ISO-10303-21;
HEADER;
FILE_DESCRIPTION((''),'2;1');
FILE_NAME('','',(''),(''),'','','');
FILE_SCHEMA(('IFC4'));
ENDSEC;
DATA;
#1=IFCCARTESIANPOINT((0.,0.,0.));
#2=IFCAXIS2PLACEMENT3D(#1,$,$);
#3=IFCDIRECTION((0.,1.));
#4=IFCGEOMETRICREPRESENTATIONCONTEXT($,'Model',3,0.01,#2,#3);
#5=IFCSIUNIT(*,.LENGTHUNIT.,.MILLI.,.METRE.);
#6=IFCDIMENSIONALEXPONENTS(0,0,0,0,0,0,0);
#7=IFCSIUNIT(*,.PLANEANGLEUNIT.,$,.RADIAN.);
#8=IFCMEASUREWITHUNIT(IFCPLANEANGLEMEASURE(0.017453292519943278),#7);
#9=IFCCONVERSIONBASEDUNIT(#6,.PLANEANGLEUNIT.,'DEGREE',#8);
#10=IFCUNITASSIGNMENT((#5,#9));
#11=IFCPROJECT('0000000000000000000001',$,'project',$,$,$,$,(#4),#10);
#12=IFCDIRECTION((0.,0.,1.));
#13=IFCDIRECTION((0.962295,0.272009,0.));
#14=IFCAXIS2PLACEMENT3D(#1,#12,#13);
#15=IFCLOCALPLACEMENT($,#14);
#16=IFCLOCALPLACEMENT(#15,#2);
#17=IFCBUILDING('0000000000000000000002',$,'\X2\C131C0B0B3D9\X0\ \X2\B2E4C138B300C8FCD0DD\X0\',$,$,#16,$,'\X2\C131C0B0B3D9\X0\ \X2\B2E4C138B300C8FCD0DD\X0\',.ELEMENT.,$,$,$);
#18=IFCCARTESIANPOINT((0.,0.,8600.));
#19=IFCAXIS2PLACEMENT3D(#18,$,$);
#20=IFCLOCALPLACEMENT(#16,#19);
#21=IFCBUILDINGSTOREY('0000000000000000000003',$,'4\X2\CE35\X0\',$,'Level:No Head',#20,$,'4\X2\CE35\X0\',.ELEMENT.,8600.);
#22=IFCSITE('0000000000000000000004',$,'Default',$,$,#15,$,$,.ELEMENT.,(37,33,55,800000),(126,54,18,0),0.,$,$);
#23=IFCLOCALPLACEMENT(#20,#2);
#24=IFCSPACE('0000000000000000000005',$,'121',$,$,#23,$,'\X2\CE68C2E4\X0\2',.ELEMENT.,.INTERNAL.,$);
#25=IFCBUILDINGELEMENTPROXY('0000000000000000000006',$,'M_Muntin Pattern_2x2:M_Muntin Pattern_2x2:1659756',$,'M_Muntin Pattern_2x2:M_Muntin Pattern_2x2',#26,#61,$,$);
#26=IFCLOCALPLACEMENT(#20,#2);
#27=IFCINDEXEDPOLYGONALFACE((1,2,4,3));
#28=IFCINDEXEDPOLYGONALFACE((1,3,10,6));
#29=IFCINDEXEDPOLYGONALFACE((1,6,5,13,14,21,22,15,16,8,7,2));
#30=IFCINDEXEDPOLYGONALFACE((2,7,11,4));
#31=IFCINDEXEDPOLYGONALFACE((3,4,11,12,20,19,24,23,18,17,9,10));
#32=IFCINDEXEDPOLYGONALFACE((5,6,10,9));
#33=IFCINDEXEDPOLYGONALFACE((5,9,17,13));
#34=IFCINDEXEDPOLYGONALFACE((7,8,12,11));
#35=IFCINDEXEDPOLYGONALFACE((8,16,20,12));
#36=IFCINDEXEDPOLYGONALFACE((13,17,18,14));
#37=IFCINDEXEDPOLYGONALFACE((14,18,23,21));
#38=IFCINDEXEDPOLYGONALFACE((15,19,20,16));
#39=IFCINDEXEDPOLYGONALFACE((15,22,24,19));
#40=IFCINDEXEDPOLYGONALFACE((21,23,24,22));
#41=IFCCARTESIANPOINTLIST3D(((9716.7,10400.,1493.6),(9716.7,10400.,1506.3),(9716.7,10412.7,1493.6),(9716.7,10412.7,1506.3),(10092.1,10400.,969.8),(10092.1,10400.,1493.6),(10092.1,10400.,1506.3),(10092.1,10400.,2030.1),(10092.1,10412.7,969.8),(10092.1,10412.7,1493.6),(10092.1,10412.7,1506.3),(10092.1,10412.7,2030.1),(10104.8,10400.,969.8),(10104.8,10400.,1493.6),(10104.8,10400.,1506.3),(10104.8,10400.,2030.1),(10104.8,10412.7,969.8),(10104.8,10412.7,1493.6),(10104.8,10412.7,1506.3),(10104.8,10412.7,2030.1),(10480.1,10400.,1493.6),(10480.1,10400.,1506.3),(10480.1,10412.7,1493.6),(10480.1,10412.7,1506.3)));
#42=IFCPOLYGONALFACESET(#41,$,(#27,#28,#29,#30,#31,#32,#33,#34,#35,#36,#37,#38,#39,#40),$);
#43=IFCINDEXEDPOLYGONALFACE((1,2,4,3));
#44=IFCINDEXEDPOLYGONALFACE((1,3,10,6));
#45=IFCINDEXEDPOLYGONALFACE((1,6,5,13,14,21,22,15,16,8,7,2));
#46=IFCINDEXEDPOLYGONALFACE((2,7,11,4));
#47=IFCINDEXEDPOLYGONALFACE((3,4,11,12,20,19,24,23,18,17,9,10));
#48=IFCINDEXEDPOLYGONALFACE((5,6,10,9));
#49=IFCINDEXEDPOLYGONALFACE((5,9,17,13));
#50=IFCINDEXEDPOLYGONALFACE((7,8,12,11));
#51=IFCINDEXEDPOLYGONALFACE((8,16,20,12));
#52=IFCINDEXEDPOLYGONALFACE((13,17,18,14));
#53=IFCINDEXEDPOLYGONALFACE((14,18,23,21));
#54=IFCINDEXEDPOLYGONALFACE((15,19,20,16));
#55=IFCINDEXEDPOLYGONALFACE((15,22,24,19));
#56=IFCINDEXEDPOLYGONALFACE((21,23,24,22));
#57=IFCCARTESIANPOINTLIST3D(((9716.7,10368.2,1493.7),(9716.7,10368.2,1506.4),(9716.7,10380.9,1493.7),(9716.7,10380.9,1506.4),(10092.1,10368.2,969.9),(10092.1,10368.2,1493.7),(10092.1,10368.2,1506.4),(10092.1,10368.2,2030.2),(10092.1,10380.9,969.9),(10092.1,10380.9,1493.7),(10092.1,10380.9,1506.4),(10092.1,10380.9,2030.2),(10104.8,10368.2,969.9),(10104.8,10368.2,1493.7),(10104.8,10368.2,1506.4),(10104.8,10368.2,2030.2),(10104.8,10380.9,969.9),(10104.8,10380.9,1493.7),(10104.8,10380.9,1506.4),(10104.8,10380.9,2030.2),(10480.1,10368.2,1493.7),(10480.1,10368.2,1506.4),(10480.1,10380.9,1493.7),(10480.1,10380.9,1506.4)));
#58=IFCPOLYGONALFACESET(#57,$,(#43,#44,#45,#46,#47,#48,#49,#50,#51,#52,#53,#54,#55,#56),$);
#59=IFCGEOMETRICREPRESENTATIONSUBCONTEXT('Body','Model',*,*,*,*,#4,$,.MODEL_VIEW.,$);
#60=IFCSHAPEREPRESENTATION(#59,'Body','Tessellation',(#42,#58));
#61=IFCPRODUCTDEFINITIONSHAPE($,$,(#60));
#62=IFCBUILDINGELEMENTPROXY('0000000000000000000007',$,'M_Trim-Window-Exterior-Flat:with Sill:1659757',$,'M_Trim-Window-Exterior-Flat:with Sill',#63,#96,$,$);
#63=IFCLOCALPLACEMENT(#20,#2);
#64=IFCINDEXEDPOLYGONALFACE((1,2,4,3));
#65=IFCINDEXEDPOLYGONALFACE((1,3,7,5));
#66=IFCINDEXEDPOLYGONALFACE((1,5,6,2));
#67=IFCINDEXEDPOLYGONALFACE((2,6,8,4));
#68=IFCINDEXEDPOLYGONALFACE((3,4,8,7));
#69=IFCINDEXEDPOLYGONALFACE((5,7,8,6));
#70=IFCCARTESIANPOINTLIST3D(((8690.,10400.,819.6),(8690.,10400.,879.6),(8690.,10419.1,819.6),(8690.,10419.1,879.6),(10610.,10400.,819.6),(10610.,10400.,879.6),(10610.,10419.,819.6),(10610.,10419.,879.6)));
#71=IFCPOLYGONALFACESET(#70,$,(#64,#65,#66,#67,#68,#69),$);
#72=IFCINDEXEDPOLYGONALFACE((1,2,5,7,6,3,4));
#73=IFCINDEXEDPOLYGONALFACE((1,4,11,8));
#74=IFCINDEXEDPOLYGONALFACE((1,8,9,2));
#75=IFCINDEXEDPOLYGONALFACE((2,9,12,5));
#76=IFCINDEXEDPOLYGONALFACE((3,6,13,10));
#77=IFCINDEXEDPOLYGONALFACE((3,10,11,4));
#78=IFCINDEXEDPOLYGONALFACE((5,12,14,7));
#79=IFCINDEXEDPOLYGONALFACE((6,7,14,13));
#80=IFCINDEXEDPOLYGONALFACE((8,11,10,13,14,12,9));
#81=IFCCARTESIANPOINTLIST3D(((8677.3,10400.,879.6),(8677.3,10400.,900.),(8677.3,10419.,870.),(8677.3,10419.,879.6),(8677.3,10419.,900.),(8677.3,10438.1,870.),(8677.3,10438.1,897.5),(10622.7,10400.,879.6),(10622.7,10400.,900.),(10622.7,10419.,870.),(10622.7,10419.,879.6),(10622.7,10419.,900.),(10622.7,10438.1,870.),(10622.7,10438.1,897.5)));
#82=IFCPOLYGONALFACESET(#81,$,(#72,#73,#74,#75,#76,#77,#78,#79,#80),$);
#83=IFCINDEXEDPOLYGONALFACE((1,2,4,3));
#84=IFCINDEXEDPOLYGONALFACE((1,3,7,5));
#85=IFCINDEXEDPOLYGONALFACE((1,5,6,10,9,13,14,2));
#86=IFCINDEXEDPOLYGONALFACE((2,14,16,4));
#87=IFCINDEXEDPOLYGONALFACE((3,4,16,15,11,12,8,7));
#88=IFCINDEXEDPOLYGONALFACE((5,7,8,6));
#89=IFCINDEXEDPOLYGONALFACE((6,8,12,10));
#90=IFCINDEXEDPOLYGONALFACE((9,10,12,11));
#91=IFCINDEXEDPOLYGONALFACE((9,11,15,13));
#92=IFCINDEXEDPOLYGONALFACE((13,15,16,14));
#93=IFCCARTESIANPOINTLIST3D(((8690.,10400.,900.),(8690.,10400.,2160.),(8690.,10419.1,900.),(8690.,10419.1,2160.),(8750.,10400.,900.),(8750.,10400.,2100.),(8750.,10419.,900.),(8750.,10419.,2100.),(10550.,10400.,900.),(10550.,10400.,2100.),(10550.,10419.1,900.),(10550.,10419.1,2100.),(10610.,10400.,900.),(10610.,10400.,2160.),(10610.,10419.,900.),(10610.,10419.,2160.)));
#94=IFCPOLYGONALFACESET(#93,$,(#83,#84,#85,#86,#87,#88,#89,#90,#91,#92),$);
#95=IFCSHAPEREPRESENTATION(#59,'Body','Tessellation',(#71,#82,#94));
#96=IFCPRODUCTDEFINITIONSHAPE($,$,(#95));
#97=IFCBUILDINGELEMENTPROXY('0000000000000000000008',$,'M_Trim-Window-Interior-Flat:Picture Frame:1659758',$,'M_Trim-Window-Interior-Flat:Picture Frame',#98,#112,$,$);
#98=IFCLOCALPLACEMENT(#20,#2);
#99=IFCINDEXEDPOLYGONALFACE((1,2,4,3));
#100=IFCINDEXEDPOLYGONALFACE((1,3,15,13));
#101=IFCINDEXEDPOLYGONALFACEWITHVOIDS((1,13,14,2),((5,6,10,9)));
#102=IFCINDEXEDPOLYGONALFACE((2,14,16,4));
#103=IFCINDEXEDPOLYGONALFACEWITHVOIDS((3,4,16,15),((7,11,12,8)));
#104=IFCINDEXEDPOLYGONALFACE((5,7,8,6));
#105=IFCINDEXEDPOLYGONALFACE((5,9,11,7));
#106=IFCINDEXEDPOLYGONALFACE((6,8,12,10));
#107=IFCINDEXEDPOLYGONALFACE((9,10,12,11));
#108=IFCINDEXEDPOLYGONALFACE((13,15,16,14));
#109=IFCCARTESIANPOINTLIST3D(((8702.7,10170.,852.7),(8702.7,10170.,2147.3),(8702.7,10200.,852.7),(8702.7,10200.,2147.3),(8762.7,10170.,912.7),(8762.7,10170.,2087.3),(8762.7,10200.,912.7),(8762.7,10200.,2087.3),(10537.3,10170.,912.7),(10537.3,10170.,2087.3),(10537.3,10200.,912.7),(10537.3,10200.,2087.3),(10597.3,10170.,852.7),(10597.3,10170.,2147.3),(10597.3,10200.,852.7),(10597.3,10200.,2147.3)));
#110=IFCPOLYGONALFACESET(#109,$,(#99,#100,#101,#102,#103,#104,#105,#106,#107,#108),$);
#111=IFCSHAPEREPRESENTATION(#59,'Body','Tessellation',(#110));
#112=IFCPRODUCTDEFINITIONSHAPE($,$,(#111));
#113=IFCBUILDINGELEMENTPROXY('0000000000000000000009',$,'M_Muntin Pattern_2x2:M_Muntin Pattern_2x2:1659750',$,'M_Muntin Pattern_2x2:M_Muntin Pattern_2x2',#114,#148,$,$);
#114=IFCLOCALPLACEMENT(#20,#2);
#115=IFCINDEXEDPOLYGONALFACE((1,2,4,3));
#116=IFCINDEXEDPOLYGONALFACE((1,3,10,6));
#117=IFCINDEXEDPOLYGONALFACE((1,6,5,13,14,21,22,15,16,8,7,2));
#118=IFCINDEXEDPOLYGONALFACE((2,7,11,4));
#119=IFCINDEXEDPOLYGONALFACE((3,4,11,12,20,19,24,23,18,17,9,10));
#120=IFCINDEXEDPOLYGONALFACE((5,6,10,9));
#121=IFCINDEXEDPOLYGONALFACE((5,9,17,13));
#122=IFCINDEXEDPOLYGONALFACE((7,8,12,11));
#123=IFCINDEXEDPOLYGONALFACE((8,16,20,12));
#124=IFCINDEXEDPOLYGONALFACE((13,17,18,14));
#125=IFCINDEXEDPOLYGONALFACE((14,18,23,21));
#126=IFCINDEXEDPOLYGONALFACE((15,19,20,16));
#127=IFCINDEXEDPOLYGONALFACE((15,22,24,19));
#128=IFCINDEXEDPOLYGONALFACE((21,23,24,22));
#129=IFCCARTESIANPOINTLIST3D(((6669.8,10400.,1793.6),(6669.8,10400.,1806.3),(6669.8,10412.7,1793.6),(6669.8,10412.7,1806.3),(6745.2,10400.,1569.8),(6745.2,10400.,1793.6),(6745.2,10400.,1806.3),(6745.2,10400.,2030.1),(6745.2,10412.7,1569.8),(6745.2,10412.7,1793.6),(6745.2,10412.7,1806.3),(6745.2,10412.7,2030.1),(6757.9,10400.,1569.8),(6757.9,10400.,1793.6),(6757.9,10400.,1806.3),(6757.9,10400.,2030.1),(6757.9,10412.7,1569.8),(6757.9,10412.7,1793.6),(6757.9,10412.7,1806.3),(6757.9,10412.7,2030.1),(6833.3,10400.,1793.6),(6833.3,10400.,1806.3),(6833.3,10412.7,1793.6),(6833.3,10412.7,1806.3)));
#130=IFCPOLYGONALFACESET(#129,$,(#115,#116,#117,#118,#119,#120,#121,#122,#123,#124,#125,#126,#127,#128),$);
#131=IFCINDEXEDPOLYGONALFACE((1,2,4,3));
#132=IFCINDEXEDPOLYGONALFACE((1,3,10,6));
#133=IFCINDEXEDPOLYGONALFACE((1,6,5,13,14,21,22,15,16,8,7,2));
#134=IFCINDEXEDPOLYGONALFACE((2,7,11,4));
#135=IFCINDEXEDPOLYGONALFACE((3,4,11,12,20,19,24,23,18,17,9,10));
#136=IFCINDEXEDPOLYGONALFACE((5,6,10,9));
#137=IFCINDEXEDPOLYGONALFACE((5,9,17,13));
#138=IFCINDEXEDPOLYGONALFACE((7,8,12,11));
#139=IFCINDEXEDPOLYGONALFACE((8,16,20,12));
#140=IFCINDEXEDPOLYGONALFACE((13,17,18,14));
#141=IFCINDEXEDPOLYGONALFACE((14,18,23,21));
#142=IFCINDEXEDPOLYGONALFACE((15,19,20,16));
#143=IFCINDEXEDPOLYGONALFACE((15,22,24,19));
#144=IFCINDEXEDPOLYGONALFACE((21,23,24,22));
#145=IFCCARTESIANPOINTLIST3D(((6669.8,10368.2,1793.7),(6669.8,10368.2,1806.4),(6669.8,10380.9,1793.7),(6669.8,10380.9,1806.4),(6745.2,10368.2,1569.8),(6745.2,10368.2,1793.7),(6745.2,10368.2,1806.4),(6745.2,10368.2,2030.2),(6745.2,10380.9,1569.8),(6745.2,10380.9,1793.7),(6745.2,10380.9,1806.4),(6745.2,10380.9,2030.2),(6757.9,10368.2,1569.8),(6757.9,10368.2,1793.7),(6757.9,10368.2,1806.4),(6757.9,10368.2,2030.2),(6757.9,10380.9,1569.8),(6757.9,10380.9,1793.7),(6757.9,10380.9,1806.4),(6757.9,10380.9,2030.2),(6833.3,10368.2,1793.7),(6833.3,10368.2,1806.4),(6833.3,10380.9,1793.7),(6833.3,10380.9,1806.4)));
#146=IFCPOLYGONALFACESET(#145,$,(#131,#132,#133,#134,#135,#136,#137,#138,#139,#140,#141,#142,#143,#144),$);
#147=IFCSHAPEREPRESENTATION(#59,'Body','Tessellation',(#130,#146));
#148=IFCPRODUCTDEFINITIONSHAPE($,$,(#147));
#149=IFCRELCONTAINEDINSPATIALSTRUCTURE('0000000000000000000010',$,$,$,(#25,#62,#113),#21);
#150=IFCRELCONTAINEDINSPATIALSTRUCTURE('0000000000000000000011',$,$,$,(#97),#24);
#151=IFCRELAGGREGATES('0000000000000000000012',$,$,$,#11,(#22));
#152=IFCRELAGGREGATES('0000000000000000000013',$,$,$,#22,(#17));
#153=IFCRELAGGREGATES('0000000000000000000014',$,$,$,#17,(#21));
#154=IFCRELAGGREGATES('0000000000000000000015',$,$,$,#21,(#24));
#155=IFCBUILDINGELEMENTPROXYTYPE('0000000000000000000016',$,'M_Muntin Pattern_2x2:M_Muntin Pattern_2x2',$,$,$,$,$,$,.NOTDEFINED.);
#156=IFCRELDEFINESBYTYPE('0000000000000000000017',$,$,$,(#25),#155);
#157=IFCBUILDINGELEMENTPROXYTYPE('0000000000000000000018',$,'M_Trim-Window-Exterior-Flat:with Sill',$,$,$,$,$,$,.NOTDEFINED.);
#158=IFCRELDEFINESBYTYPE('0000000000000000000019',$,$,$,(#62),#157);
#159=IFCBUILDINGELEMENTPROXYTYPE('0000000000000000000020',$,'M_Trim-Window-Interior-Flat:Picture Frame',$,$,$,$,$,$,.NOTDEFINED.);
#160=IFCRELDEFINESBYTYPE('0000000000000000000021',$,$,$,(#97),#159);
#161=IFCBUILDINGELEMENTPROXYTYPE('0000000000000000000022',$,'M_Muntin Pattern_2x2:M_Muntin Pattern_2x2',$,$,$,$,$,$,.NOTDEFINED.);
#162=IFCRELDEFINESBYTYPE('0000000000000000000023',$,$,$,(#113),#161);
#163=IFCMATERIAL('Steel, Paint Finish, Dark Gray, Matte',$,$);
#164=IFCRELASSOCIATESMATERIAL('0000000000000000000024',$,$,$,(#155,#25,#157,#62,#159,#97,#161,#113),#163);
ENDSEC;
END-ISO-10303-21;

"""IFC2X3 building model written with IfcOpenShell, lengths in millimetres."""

from ifc_helpers import new_model, entity, si_unit, converted_unit, direction, frame, frame_2d, origin, place, context, subcontext, project, spatial, polyline, rectangle, outline, extrude, source, transform, mapped, material, type_object, type_shapes, element, save


model = new_model("IFC2X3")

# Units and contexts
model_context = context("Model", 3, precision=0.01, world=origin(), true_north=direction((0.0, 1.0)))
body_context = subcontext(model_context, "Body", "Model", "MODEL_VIEW")
ifc_project = project(units=[si_unit("LENGTHUNIT", "METRE", prefix="MILLI"), converted_unit("PLANEANGLEUNIT", "DEGREE", entity("IfcPlaneAngleMeasure", 0.017453292519943278), si_unit("PLANEANGLEUNIT", "RADIAN"), dimensions=[0, 0, 0, 0, 0, 0, 0])], contexts=[model_context])

# Site, building, storey
site_placement = place(None, frame((0.0, 0.0, 0.0), z_axis=(0.0, 0.0, 1.0), x_axis=(0.962295, 0.272009, 0.0)))
site = spatial("IfcSite", under=ifc_project, at=site_placement, Name="Default", CompositionType="ELEMENT", RefLatitude=(37, 33, 55, 800000), RefLongitude=(126, 54, 18, 0), RefElevation=0.0)
building_placement = place(site_placement, origin())
building = spatial("IfcBuilding", under=site, at=building_placement, Name="성산동 다세대주택", LongName="성산동 다세대주택", CompositionType="ELEMENT")
storey_placement = place(building_placement, frame((0.0, 0.0, 8600.0)))
storey = spatial("IfcBuildingStorey", under=building, at=storey_placement, Name="4층", ObjectType="Level:No Head", LongName="4층", CompositionType="ELEMENT", Elevation=8600.0)

# Shared definitions
space_1_placement = place(storey_placement, origin())
space_1 = spatial("IfcSpace", under=storey, at=space_1_placement, Name="121", LongName="침실2", CompositionType="ELEMENT", InteriorOrExteriorSpace="INTERNAL")

# Building element proxies
ifc_material_1 = material(Name="Steel, Paint Finish, Dark Gray, Matte")
building_element_proxy_type_1 = type_object("IfcBuildingElementProxyType", Name="M_Muntin Pattern_2x2:M_Muntin Pattern_2x2", PredefinedType="NOTDEFINED", material=ifc_material_1)
shared_shape_1 = source(origin(), body_context, "Body", "SweptSolid", [
    extrude(outline(polyline([(6.4, -6.4), (530.1, -6.4), (530.1, 6.3), (6.4, 6.3), (6.4, 381.7), (-6.3, 381.7), (-6.3, 6.3), (-530.2, 6.3), (-530.2, -6.4), (-6.3, -6.4), (-6.3, -381.7), (6.4, -381.7), (6.4, -6.4)])), frame((0.0, -22.2, 530.1), z_axis=(0.0, 1.0, 0.0), x_axis=(0.0, 0.0, 1.0)), (0.0, 0.0, 1.0), 12.7),
    extrude(outline(polyline([(6.4, -6.4), (530.2, -6.4), (530.2, 6.3), (6.4, 6.3), (6.4, 381.7), (-6.3, 381.7), (-6.3, 6.3), (-530.2, 6.3), (-530.2, -6.4), (-6.3, -6.4), (-6.3, -381.7), (6.4, -381.7), (6.4, -6.4)])), frame((0.0, 9.5, 530.2), z_axis=(0.0, 1.0, 0.0), x_axis=(0.0, 0.0, 1.0)), (0.0, 0.0, 1.0), 12.7),
])
type_shapes(building_element_proxy_type_1, [shared_shape_1])
proxy_1_placement = place(storey_placement, frame((10098.4, 10390.5, 969.9), z_axis=(0.0, 0.0, 1.0), x_axis=(-1.0, 0.0, 0.0)))
element("IfcBuildingElementProxy", 1, at=proxy_1_placement, inside=storey, type_object=building_element_proxy_type_1, material=ifc_material_1, Name="M_Muntin Pattern_2x2:M_Muntin Pattern_2x2:1659756", ObjectType="M_Muntin Pattern_2x2:M_Muntin Pattern_2x2", context=body_context, shape_type="MappedRepresentation", body=[
    mapped(shared_shape_1, transform((0.0, 0.0, 0.0), scale=1.0)),
])
building_element_proxy_type_2 = type_object("IfcBuildingElementProxyType", Name="M_Trim-Window-Exterior-Flat:with Sill", PredefinedType="NOTDEFINED", material=ifc_material_1)
shared_shape_2 = source(origin(), body_context, "Body", "SweptSolid", [
    extrude(rectangle(XDim=1920.0, YDim=60.0, at=frame_2d((0.0, 0.0), x_axis=(1.0, 0.0))), frame((0.0, -1250.4, 0.0), z_axis=(0.0, 0.0, 1.0), x_axis=(-1.0, 0.0, 0.0)), (0.0, 0.0, 1.0), 19.0),
    extrude(outline(polyline([(-19.0, -15.2), (0.0, -15.2), (0.0, -5.7), (19.0, -5.7), (19.0, 14.8), (0.0, 14.8), (-19.0, 12.3), (-19.0, -15.2)])), frame((-972.7, -1214.8, 19.0), z_axis=(1.0, 0.0, 0.0), x_axis=(0.0, 0.0, -1.0)), (0.0, 0.0, 1.0), 1945.4),
    extrude(outline(polyline([(-645.0, -960.0), (615.0, -960.0), (615.0, -900.0), (-585.0, -900.0), (-585.0, 900.0), (615.0, 900.0), (615.0, 960.0), (-645.0, 960.0), (-645.0, -960.0)])), frame((0.0, -585.0, 0.0), z_axis=(0.0, 0.0, 1.0), x_axis=(0.0, -1.0, 0.0)), (0.0, 0.0, 1.0), 19.0),
])
type_shapes(building_element_proxy_type_2, [shared_shape_2])
proxy_2_placement = place(storey_placement, frame((9650.0, 10400.0, 2100.0), z_axis=(0.0, 1.0, 0.0), x_axis=(-1.0, 0.0, 0.0)))
element("IfcBuildingElementProxy", 2, at=proxy_2_placement, inside=storey, type_object=building_element_proxy_type_2, material=ifc_material_1, Name="M_Trim-Window-Exterior-Flat:with Sill:1659757", ObjectType="M_Trim-Window-Exterior-Flat:with Sill", context=body_context, shape_type="MappedRepresentation", body=[
    mapped(shared_shape_2, transform((0.0, 0.0, 0.0), scale=1.0)),
])
building_element_proxy_type_3 = type_object("IfcBuildingElementProxyType", Name="M_Trim-Window-Interior-Flat:Picture Frame", PredefinedType="NOTDEFINED", material=ifc_material_1)
shared_shape_3 = source(origin(), body_context, "Body", "SweptSolid", [
    extrude(outline(polyline([(-947.3, -647.3), (947.3, -647.3), (947.3, 647.3), (-947.3, 647.3), (-947.3, -647.3)]), holes=[polyline([(-887.3, -587.3), (-887.3, 587.3), (887.3, 587.3), (887.3, -587.3), (-887.3, -587.3)])]), frame((0.0, -600.0, 0.0), z_axis=(0.0, 0.0, 1.0), x_axis=(-1.0, 0.0, 0.0)), (0.0, 0.0, 1.0), 30.0),
])
type_shapes(building_element_proxy_type_3, [shared_shape_3])
proxy_3_placement = place(space_1_placement, frame((9650.0, 10200.0, 2100.0), z_axis=(0.0, -1.0, 0.0), x_axis=(1.0, 0.0, 0.0)))
element("IfcBuildingElementProxy", 3, at=proxy_3_placement, inside=space_1, type_object=building_element_proxy_type_3, material=ifc_material_1, Name="M_Trim-Window-Interior-Flat:Picture Frame:1659758", ObjectType="M_Trim-Window-Interior-Flat:Picture Frame", context=body_context, shape_type="MappedRepresentation", body=[
    mapped(shared_shape_3, transform((0.0, 0.0, 0.0), scale=1.0)),
])
building_element_proxy_type_4 = type_object("IfcBuildingElementProxyType", Name="M_Muntin Pattern_2x2:M_Muntin Pattern_2x2", PredefinedType="NOTDEFINED", material=ifc_material_1)
shared_shape_4 = source(origin(), body_context, "Body", "SweptSolid", [
    extrude(outline(polyline([(6.4, -6.4), (230.1, -6.4), (230.1, 6.3), (6.4, 6.3), (6.4, 81.7), (-6.3, 81.7), (-6.3, 6.3), (-230.2, 6.3), (-230.2, -6.4), (-6.3, -6.4), (-6.3, -81.7), (6.4, -81.7), (6.4, -6.4)])), frame((0.0, 9.5, 230.1), z_axis=(0.0, 1.0, 0.0), x_axis=(0.0, 0.0, 1.0)), (0.0, 0.0, 1.0), 12.7),
    extrude(outline(polyline([(6.4, -6.4), (230.2, -6.4), (230.2, 6.3), (6.4, 6.3), (6.4, 81.7), (-6.3, 81.7), (-6.3, 6.3), (-230.2, 6.3), (-230.2, -6.4), (-6.3, -6.4), (-6.3, -81.7), (6.4, -81.7), (6.4, -6.4)])), frame((0.0, -22.2, 230.2), z_axis=(0.0, 1.0, 0.0), x_axis=(0.0, 0.0, 1.0)), (0.0, 0.0, 1.0), 12.7),
])
type_shapes(building_element_proxy_type_4, [shared_shape_4])
proxy_4_placement = place(storey_placement, frame((6751.6, 10390.5, 1569.8)))
element("IfcBuildingElementProxy", 4, at=proxy_4_placement, inside=storey, type_object=building_element_proxy_type_4, material=ifc_material_1, Name="M_Muntin Pattern_2x2:M_Muntin Pattern_2x2:1659750", ObjectType="M_Muntin Pattern_2x2:M_Muntin Pattern_2x2", context=body_context, shape_type="MappedRepresentation", body=[
    mapped(shared_shape_4, transform((0.0, 0.0, 0.0), scale=1.0)),
])

save(model, "model.ifc")
